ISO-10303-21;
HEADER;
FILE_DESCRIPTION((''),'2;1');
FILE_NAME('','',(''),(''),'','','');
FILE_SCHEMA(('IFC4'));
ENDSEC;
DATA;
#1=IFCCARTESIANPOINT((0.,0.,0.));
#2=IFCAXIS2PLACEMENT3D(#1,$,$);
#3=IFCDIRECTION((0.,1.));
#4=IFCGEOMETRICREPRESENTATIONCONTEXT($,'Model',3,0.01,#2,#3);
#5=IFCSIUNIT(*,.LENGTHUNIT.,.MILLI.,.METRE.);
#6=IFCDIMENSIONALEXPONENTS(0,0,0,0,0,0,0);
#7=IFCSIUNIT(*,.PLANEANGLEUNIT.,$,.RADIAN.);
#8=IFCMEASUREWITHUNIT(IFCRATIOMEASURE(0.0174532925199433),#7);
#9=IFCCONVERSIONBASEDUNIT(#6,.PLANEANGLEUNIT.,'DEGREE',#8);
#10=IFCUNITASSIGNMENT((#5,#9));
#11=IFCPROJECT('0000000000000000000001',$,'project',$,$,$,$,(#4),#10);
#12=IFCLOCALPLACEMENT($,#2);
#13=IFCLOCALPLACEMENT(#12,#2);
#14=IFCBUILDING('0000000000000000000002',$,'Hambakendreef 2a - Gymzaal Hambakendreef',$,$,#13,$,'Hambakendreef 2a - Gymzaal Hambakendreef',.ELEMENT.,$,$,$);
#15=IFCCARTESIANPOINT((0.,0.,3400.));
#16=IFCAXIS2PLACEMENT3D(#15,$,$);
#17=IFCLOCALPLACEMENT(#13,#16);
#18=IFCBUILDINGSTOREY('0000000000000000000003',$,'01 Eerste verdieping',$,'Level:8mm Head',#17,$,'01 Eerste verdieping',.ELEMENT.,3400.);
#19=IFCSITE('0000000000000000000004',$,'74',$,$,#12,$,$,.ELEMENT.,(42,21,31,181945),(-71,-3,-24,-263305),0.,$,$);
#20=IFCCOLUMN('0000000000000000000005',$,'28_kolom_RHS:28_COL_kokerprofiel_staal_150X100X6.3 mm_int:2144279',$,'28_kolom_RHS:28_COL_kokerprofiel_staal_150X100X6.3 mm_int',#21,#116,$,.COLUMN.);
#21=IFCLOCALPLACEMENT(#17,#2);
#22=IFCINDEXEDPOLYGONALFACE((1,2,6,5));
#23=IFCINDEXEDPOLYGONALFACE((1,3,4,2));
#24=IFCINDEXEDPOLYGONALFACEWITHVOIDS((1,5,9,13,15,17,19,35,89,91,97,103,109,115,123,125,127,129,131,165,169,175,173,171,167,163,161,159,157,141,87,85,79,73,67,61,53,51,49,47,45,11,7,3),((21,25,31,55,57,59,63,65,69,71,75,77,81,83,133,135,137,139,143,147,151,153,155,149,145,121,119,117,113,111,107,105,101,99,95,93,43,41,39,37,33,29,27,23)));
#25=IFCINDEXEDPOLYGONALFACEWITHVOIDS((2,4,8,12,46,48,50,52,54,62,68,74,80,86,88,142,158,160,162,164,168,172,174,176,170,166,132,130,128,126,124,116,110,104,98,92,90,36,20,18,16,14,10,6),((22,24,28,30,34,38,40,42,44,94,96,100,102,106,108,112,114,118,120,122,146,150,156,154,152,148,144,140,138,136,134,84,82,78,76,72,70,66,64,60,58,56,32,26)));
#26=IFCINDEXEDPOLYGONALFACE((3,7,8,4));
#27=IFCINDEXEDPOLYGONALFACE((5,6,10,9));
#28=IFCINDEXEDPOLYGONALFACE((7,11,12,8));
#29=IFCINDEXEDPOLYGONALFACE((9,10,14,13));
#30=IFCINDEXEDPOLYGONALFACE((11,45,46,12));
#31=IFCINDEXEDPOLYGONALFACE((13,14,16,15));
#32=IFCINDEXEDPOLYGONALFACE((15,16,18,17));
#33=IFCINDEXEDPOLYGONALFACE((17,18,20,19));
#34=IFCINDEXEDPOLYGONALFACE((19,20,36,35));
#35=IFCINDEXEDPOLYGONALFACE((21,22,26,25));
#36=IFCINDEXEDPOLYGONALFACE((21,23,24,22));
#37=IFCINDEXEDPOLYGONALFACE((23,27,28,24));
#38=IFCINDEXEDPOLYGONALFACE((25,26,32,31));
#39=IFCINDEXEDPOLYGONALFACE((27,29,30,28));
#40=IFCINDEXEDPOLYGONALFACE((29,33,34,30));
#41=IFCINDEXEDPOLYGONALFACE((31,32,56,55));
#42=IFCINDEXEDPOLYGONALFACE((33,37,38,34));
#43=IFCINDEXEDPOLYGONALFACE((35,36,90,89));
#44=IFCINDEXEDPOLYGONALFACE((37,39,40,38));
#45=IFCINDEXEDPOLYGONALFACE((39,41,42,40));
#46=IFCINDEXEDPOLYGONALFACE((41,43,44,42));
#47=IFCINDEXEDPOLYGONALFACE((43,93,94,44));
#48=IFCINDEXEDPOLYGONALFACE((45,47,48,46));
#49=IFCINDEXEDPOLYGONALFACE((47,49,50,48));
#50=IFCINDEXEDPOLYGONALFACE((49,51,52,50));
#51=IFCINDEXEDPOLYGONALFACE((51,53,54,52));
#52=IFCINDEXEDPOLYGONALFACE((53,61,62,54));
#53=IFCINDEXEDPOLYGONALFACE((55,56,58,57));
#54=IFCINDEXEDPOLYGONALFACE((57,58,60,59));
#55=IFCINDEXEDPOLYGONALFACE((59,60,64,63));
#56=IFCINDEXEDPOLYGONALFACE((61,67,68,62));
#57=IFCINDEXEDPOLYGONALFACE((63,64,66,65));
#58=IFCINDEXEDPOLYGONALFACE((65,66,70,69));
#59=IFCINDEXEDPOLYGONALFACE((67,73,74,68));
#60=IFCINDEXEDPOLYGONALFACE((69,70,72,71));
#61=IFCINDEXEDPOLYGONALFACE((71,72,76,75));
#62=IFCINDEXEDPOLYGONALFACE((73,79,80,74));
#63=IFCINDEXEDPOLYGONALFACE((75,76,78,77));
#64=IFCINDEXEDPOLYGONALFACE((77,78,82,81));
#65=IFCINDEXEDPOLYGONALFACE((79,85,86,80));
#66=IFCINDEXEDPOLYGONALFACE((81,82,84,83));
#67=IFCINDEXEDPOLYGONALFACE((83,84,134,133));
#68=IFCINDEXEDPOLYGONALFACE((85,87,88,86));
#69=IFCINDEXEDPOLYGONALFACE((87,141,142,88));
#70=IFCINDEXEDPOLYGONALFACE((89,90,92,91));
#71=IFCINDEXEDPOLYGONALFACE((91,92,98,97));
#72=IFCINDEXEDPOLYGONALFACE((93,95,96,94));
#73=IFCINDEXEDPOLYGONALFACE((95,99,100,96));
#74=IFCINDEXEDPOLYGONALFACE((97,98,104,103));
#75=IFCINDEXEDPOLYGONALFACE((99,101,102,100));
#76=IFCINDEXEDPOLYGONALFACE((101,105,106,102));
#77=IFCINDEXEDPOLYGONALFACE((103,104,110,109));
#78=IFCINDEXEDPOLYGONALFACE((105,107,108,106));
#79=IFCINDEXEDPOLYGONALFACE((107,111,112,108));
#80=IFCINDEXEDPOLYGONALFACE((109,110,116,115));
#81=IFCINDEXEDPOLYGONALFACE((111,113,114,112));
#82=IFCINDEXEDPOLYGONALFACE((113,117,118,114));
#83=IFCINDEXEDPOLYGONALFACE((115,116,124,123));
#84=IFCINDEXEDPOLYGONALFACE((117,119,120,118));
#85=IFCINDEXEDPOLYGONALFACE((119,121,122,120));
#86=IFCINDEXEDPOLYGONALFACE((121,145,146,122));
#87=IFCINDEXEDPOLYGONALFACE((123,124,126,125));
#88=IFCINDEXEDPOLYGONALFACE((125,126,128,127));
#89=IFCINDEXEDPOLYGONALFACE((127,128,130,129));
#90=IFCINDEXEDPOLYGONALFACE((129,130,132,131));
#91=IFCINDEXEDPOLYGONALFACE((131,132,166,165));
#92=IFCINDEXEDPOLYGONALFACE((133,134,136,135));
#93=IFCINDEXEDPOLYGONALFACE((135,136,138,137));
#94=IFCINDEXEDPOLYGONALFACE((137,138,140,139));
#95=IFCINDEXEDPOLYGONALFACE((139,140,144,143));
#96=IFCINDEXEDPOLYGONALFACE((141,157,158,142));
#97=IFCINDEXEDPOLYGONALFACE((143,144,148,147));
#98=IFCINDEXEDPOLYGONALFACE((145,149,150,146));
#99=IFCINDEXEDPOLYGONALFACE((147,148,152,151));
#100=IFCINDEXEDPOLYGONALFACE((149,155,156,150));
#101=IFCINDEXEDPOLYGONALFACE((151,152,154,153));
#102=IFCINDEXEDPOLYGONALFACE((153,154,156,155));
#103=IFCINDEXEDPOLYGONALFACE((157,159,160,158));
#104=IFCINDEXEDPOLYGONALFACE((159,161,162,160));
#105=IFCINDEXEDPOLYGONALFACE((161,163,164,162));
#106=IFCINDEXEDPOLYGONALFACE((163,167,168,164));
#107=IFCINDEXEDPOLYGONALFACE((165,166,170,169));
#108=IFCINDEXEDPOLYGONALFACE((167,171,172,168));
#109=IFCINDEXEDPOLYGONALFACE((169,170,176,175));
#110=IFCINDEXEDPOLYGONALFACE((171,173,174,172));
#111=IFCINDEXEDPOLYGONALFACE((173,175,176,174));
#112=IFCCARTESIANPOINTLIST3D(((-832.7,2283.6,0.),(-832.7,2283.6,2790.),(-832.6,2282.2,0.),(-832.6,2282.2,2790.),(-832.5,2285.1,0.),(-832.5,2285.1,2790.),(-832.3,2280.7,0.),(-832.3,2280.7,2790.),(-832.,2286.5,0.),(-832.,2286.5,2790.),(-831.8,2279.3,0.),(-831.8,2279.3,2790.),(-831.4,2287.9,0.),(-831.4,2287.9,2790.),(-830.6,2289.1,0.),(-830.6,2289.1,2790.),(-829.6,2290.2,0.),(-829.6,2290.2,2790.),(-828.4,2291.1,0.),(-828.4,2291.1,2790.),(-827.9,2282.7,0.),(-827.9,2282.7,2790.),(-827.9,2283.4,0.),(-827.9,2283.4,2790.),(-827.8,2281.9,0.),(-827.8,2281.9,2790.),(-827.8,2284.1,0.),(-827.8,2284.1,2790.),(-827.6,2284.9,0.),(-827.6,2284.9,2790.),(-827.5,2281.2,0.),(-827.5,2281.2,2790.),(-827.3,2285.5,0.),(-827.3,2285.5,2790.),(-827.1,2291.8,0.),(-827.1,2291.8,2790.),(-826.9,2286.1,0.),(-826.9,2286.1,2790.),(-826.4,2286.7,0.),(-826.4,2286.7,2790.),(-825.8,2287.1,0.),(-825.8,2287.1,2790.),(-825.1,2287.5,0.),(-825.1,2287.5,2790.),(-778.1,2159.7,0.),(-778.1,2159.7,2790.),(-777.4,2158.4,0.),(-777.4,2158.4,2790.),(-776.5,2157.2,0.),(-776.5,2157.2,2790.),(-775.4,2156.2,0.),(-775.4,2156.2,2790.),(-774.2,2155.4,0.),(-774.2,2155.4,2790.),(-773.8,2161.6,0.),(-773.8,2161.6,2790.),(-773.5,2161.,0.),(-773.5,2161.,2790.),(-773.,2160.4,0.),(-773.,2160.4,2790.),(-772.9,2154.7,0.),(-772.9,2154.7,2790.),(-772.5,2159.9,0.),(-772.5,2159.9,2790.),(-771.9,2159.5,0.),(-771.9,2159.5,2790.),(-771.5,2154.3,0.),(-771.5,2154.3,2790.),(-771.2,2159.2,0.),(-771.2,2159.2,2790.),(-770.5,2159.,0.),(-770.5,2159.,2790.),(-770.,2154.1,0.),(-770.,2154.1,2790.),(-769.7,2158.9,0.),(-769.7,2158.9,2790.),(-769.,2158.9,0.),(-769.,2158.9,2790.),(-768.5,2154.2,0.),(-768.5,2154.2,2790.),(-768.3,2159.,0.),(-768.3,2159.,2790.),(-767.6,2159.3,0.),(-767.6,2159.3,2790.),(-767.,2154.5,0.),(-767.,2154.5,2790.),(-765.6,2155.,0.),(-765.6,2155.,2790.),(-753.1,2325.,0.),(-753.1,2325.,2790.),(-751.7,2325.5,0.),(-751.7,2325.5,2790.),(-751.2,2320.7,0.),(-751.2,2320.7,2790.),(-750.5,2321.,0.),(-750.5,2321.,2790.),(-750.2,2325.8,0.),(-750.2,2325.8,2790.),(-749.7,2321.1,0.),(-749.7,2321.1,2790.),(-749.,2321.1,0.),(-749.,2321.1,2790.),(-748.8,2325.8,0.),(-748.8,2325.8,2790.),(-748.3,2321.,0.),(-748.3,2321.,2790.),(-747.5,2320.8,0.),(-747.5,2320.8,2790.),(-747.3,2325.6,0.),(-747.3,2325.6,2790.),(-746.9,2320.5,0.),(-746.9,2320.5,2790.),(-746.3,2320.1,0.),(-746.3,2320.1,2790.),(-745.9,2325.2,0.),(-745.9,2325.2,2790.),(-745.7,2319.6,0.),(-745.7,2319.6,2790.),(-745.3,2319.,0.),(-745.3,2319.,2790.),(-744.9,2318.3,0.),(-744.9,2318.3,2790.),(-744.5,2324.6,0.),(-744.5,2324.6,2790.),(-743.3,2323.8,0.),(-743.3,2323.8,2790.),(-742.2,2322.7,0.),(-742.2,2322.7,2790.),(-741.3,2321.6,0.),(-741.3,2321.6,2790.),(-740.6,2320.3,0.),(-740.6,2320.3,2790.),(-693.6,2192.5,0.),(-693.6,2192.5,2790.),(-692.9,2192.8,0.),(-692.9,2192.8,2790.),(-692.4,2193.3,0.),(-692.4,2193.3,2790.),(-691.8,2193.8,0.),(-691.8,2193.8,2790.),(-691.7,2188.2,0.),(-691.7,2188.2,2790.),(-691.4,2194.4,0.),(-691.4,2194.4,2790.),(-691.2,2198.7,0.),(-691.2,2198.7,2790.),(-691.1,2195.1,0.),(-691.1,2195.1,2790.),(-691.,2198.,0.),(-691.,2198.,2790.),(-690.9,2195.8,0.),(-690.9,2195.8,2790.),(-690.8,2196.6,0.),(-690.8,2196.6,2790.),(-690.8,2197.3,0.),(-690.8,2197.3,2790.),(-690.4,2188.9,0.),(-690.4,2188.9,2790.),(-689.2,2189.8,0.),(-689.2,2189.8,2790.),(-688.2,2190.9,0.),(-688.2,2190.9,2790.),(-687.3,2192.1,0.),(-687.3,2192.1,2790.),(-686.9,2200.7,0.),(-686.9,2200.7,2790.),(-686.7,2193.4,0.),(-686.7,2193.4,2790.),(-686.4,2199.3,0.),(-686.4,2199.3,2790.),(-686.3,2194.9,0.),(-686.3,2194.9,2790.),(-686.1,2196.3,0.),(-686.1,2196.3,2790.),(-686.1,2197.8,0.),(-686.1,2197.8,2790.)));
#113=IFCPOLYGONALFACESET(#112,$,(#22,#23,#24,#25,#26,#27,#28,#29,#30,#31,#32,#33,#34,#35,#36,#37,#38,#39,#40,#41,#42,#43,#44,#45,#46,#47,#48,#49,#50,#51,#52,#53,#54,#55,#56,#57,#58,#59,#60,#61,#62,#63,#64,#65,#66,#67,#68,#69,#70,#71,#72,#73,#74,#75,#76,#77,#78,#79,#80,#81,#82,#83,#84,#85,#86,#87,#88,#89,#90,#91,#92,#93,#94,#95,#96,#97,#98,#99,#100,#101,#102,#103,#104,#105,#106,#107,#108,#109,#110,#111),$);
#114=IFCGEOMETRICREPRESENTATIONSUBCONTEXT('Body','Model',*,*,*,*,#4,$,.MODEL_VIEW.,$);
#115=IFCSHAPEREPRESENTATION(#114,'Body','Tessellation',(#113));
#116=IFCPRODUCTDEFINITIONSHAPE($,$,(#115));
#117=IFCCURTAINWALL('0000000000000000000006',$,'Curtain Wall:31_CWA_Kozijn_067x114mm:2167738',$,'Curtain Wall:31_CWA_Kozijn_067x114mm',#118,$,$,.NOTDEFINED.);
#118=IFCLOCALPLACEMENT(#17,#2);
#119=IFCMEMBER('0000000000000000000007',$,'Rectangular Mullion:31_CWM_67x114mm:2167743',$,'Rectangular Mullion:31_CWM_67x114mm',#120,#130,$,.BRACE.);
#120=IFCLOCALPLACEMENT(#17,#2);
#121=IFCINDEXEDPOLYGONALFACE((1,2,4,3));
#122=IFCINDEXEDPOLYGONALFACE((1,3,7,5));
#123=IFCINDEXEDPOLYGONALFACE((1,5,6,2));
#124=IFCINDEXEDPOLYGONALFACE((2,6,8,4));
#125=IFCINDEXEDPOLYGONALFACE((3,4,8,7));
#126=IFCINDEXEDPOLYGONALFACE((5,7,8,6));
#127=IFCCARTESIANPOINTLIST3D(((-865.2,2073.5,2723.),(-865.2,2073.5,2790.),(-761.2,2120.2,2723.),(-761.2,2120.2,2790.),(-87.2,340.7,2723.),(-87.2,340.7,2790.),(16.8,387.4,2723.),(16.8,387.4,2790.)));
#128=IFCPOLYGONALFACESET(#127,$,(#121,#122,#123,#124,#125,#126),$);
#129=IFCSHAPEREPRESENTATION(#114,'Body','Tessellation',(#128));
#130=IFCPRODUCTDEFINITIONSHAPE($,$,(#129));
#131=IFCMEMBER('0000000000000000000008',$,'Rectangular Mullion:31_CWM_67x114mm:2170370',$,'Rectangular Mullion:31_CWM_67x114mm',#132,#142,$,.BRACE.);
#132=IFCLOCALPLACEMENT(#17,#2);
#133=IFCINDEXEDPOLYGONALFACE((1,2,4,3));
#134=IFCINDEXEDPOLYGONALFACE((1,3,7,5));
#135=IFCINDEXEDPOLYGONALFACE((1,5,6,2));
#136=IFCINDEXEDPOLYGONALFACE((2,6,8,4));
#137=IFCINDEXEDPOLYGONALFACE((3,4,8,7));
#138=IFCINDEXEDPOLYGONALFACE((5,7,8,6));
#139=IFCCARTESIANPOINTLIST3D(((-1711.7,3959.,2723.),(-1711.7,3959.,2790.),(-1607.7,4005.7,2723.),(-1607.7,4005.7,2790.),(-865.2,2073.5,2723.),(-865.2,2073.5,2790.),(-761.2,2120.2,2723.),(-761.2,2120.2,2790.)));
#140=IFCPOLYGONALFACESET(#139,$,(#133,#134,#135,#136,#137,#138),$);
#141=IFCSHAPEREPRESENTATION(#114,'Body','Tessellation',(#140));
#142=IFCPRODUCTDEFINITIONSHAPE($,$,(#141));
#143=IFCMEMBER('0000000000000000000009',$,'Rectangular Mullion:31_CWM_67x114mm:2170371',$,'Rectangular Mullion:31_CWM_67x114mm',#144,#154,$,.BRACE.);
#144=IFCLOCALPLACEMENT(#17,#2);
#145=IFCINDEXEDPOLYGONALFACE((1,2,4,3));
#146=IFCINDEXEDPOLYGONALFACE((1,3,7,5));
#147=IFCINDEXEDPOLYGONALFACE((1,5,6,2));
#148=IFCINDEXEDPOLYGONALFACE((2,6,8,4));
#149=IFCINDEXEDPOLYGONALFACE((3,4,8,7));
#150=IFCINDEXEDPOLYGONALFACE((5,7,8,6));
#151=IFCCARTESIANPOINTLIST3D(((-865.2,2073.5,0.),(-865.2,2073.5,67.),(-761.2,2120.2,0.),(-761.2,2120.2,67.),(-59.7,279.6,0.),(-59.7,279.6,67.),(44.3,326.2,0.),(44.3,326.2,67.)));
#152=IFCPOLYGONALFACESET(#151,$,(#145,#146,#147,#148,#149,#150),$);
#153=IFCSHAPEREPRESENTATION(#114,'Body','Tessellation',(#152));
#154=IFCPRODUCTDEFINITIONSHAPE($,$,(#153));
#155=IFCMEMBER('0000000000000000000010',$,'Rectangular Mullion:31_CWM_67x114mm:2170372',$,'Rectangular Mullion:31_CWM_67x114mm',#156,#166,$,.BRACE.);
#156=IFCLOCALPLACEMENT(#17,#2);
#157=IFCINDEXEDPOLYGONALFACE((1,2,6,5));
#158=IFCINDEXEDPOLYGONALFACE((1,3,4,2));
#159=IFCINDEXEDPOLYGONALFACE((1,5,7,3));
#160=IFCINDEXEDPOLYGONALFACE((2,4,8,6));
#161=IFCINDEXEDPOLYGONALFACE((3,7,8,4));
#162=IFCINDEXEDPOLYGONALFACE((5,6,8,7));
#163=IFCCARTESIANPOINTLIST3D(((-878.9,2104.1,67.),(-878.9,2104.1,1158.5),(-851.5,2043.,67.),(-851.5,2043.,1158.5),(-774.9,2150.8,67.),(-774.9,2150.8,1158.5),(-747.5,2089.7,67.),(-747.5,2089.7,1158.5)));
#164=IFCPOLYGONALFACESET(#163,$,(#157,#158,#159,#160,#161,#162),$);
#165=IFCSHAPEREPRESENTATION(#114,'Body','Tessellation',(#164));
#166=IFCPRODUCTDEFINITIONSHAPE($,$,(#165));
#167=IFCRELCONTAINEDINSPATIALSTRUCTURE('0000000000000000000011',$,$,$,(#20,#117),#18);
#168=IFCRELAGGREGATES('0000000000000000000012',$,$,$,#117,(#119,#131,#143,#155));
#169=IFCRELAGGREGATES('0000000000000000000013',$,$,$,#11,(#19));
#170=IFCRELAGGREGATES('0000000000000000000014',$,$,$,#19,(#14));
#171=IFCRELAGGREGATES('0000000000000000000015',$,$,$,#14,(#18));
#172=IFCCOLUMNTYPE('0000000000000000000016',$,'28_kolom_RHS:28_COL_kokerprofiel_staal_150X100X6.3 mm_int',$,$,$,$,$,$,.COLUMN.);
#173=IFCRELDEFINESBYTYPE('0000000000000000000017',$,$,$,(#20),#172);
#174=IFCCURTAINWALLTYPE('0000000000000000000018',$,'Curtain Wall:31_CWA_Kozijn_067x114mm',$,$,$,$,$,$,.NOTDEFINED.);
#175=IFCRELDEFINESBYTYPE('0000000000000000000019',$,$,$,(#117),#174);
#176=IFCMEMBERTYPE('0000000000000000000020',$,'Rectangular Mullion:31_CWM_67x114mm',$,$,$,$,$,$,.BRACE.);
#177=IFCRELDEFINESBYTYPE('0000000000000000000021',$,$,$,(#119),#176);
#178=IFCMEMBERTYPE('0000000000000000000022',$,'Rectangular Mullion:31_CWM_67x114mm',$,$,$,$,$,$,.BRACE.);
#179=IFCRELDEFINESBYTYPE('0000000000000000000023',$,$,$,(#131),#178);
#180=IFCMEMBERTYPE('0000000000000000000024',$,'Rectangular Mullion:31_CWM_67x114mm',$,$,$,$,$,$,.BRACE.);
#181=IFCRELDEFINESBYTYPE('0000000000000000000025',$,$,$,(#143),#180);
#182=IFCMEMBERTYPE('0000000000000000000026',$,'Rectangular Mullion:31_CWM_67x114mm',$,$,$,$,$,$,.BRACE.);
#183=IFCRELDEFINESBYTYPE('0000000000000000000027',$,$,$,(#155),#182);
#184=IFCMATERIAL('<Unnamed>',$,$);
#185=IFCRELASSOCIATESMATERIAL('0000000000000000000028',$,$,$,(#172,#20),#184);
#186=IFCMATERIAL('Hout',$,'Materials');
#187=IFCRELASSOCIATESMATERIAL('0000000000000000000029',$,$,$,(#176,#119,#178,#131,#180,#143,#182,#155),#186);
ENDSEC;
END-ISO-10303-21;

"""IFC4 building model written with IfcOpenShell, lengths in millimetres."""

from ifc_helpers import new_model, entity, si_unit, converted_unit, direction, frame, origin, place, context, subcontext, project, spatial, indexed_curve, outline, extrude, source, transform, mapped, material, type_object, type_shapes, element, aggregate, save


model = new_model("IFC4")

# Units and contexts
model_context = context("Model", 3, precision=0.01, world=origin(), true_north=direction((0.0, 1.0)))
body_context = subcontext(model_context, "Body", "Model", "MODEL_VIEW")
ifc_project = project(units=[si_unit("LENGTHUNIT", "METRE", prefix="MILLI"), converted_unit("PLANEANGLEUNIT", "DEGREE", entity("IfcRatioMeasure", 0.0174532925199433), si_unit("PLANEANGLEUNIT", "RADIAN"), dimensions=[0, 0, 0, 0, 0, 0, 0])], contexts=[model_context])

# Site, building, storey
site_placement = place(None, origin())
site = spatial("IfcSite", under=ifc_project, at=site_placement, Name="74", CompositionType="ELEMENT", RefLatitude=(42, 21, 31, 181945), RefLongitude=(-71, -3, -24, -263305), RefElevation=0.0)
building_placement = place(site_placement, origin())
building = spatial("IfcBuilding", under=site, at=building_placement, Name="Hambakendreef 2a - Gymzaal Hambakendreef", LongName="Hambakendreef 2a - Gymzaal Hambakendreef", CompositionType="ELEMENT")
storey_placement = place(building_placement, frame((0.0, 0.0, 3400.0)))
storey = spatial("IfcBuildingStorey", under=building, at=storey_placement, Name="01 Eerste verdieping", ObjectType="Level:8mm Head", LongName="01 Eerste verdieping", CompositionType="ELEMENT", Elevation=3400.0)

# Column
ifc_material_1 = material(Name="<Unnamed>")
column_type = type_object("IfcColumnType", Name="28_kolom_RHS:28_COL_kokerprofiel_staal_150X100X6.3 mm_int", PredefinedType="COLUMN", material=ifc_material_1)
shared_shape_1 = source(origin(), body_context, "Body", "SweptSolid", [
    extrude(outline(indexed_curve([(-40.5, -75.0), (40.5, -75.0), (42.0, -74.9), (43.5, -74.5), (44.8, -74.0), (46.1, -73.2), (47.2, -72.2), (48.2, -71.1), (49.0, -69.8), (49.5, -68.5), (49.9, -67.0), (50.0, -65.6), (50.0, 65.6), (49.9, 67.0), (49.5, 68.5), (49.0, 69.8), (48.2, 71.1), (47.2, 72.2), (46.1, 73.2), (44.8, 74.0), (43.5, 74.5), (42.0, 74.9), (40.5, 75.0), (-40.5, 75.0), (-42.0, 74.9), (-43.5, 74.5), (-44.8, 74.0), (-46.1, 73.2), (-47.2, 72.2), (-48.2, 71.1), (-49.0, 69.8), (-49.5, 68.5), (-49.9, 67.0), (-50.0, 65.6), (-50.0, -65.6), (-49.9, -67.0), (-49.5, -68.5), (-49.0, -69.8), (-48.2, -71.1), (-47.2, -72.2), (-46.1, -73.2), (-44.8, -74.0), (-43.5, -74.5), (-42.0, -74.9), (-40.5, -75.0)], self_intersect=False), holes=[indexed_curve([(-45.3, 65.5), (-45.2, 66.3), (-45.0, 67.0), (-44.8, 67.7), (-44.4, 68.3), (-43.9, 68.9), (-43.3, 69.4), (-42.7, 69.8), (-42.0, 70.0), (-41.3, 70.2), (-40.6, 70.3), (40.5, 70.3), (41.3, 70.2), (42.0, 70.0), (42.7, 69.8), (43.3, 69.4), (43.9, 68.9), (44.4, 68.3), (44.8, 67.7), (45.0, 67.0), (45.2, 66.3), (45.3, 65.5), (45.3, -65.5), (45.2, -66.3), (45.0, -67.0), (44.8, -67.7), (44.4, -68.3), (43.9, -68.9), (43.3, -69.4), (42.7, -69.8), (42.0, -70.0), (41.3, -70.2), (40.5, -70.3), (-40.6, -70.3), (-41.3, -70.2), (-42.0, -70.0), (-42.7, -69.8), (-43.3, -69.4), (-43.9, -68.9), (-44.4, -68.3), (-44.8, -67.7), (-45.0, -67.0), (-45.2, -66.3), (-45.3, -65.5), (-45.3, 65.5)], self_intersect=False)]), frame((235.6, 34.3, 3400.0), z_axis=(0.0, 0.0, 1.0), x_axis=(0.0, 1.0, 0.0)), (0.0, 0.0, 1.0), 2790.0),
])
type_shapes(column_type, [shared_shape_1])
column_placement = place(storey_placement, frame((-887.1, 2440.9, -3400.0), z_axis=(0.0, 0.0, 1.0), x_axis=(0.40959, -0.91227, 0.0)))
element("IfcColumn", 1, at=column_placement, inside=storey, type_object=column_type, material=ifc_material_1, Name="28_kolom_RHS:28_COL_kokerprofiel_staal_150X100X6.3 mm_int:2144279", ObjectType="28_kolom_RHS:28_COL_kokerprofiel_staal_150X100X6.3 mm_int", PredefinedType="COLUMN", context=body_context, shape_type="MappedRepresentation", body=[
    mapped(shared_shape_1, transform((0.0, 0.0, 0.0), scale=1.0)),
])

# Curtain wall, members
curtain_wall_type = type_object("IfcCurtainWallType", Name="Curtain Wall:31_CWA_Kozijn_067x114mm", PredefinedType="NOTDEFINED")
curtain_wall_placement = place(storey_placement, frame((0.0, 0.0, -3400.0)))
curtain_wall = element("IfcCurtainWall", 2, at=curtain_wall_placement, inside=storey, type_object=curtain_wall_type, Name="Curtain Wall:31_CWA_Kozijn_067x114mm:2167738", ObjectType="Curtain Wall:31_CWA_Kozijn_067x114mm", PredefinedType="NOTDEFINED")
ifc_material_2 = material(Name="Hout", Category="Materials")
member_type_1 = type_object("IfcMemberType", Name="Rectangular Mullion:31_CWM_67x114mm", PredefinedType="BRACE", material=ifc_material_2)
shared_shape_2 = source(origin(), body_context, "Body", "SweptSolid", [
    extrude(outline(indexed_curve([(-57.0, -33.5), (57.0, -33.5), (57.0, 33.5), (-57.0, 33.5), (-57.0, -33.5)], self_intersect=False)), frame((-33.5, 0.0, -1899.5), z_axis=(0.0, 0.0, 1.0), x_axis=(0.0, -1.0, 0.0)), (0.0, 0.0, 1.0), 1899.5),
])
type_shapes(member_type_1, [shared_shape_2])
member_1_placement = place(storey_placement, frame((-35.2, 364.0, 2790.0), z_axis=(0.40959, -0.91227, 0.0), x_axis=(0.0, 0.0, 1.0)))
member_1 = element("IfcMember", 3, at=member_1_placement, type_object=member_type_1, material=ifc_material_2, Name="Rectangular Mullion:31_CWM_67x114mm:2167743", ObjectType="Rectangular Mullion:31_CWM_67x114mm", PredefinedType="BRACE", context=body_context, shape_type="MappedRepresentation", body=[
    mapped(shared_shape_2, transform((0.0, 0.0, 0.0), scale=1.0)),
])
member_type_2 = type_object("IfcMemberType", Name="Rectangular Mullion:31_CWM_67x114mm", PredefinedType="BRACE", material=ifc_material_2)
shared_shape_3 = source(origin(), body_context, "Body", "SweptSolid", [
    extrude(outline(indexed_curve([(-57.0, -33.5), (57.0, -33.5), (57.0, 33.5), (-57.0, 33.5), (-57.0, -33.5)], self_intersect=False)), frame((-33.5, 0.0, -2066.8), z_axis=(0.0, 0.0, 1.0), x_axis=(0.0, -1.0, 0.0)), (0.0, 0.0, 1.0), 2066.8),
])
type_shapes(member_type_2, [shared_shape_3])
member_2_placement = place(storey_placement, frame((-813.2, 2096.9, 2790.0), z_axis=(0.40959, -0.91227, 0.0), x_axis=(0.0, 0.0, 1.0)))
member_2 = element("IfcMember", 4, at=member_2_placement, type_object=member_type_2, material=ifc_material_2, Name="Rectangular Mullion:31_CWM_67x114mm:2170370", ObjectType="Rectangular Mullion:31_CWM_67x114mm", PredefinedType="BRACE", context=body_context, shape_type="MappedRepresentation", body=[
    mapped(shared_shape_3, transform((0.0, 0.0, 0.0), scale=1.0)),
])
member_type_3 = type_object("IfcMemberType", Name="Rectangular Mullion:31_CWM_67x114mm", PredefinedType="BRACE", material=ifc_material_2)
shared_shape_4 = source(origin(), body_context, "Body", "SweptSolid", [
    extrude(outline(indexed_curve([(-57.0, -33.5), (57.0, -33.5), (57.0, 33.5), (-57.0, 33.5), (-57.0, -33.5)], self_intersect=False)), frame((-33.5, 0.0, -1966.5), z_axis=(0.0, 0.0, 1.0), x_axis=(0.0, -1.0, 0.0)), (0.0, 0.0, 1.0), 1966.5),
])
type_shapes(member_type_3, [shared_shape_4])
member_3_placement = place(storey_placement, frame((-813.2, 2096.9, 0.0), z_axis=(-0.40959, 0.91227, 0.0), x_axis=(0.0, 0.0, -1.0)))
member_3 = element("IfcMember", 5, at=member_3_placement, type_object=member_type_3, material=ifc_material_2, Name="Rectangular Mullion:31_CWM_67x114mm:2170371", ObjectType="Rectangular Mullion:31_CWM_67x114mm", PredefinedType="BRACE", context=body_context, shape_type="MappedRepresentation", body=[
    mapped(shared_shape_4, transform((0.0, 0.0, 0.0), scale=1.0)),
])
member_type_4 = type_object("IfcMemberType", Name="Rectangular Mullion:31_CWM_67x114mm", PredefinedType="BRACE", material=ifc_material_2)
shared_shape_5 = source(origin(), body_context, "Body", "SweptSolid", [
    extrude(outline(indexed_curve([(-57.0, -33.5), (57.0, -33.5), (57.0, 33.5), (-57.0, 33.5), (-57.0, -33.5)], self_intersect=False)), frame((0.0, 0.0, -1091.5), z_axis=(0.0, 0.0, 1.0), x_axis=(0.0, -1.0, 0.0)), (0.0, 0.0, 1.0), 1091.5),
])
type_shapes(member_type_4, [shared_shape_5])
member_4_placement = place(storey_placement, frame((-813.2, 2096.9, 67.0), z_axis=(0.0, 0.0, -1.0), x_axis=(0.40959, -0.91227, 0.0)))
member_4 = element("IfcMember", 6, at=member_4_placement, type_object=member_type_4, material=ifc_material_2, Name="Rectangular Mullion:31_CWM_67x114mm:2170372", ObjectType="Rectangular Mullion:31_CWM_67x114mm", PredefinedType="BRACE", context=body_context, shape_type="MappedRepresentation", body=[
    mapped(shared_shape_5, transform((0.0, 0.0, 0.0), scale=1.0)),
])
aggregate(curtain_wall, [member_1, member_2, member_3, member_4])

save(model, "model.ifc")
